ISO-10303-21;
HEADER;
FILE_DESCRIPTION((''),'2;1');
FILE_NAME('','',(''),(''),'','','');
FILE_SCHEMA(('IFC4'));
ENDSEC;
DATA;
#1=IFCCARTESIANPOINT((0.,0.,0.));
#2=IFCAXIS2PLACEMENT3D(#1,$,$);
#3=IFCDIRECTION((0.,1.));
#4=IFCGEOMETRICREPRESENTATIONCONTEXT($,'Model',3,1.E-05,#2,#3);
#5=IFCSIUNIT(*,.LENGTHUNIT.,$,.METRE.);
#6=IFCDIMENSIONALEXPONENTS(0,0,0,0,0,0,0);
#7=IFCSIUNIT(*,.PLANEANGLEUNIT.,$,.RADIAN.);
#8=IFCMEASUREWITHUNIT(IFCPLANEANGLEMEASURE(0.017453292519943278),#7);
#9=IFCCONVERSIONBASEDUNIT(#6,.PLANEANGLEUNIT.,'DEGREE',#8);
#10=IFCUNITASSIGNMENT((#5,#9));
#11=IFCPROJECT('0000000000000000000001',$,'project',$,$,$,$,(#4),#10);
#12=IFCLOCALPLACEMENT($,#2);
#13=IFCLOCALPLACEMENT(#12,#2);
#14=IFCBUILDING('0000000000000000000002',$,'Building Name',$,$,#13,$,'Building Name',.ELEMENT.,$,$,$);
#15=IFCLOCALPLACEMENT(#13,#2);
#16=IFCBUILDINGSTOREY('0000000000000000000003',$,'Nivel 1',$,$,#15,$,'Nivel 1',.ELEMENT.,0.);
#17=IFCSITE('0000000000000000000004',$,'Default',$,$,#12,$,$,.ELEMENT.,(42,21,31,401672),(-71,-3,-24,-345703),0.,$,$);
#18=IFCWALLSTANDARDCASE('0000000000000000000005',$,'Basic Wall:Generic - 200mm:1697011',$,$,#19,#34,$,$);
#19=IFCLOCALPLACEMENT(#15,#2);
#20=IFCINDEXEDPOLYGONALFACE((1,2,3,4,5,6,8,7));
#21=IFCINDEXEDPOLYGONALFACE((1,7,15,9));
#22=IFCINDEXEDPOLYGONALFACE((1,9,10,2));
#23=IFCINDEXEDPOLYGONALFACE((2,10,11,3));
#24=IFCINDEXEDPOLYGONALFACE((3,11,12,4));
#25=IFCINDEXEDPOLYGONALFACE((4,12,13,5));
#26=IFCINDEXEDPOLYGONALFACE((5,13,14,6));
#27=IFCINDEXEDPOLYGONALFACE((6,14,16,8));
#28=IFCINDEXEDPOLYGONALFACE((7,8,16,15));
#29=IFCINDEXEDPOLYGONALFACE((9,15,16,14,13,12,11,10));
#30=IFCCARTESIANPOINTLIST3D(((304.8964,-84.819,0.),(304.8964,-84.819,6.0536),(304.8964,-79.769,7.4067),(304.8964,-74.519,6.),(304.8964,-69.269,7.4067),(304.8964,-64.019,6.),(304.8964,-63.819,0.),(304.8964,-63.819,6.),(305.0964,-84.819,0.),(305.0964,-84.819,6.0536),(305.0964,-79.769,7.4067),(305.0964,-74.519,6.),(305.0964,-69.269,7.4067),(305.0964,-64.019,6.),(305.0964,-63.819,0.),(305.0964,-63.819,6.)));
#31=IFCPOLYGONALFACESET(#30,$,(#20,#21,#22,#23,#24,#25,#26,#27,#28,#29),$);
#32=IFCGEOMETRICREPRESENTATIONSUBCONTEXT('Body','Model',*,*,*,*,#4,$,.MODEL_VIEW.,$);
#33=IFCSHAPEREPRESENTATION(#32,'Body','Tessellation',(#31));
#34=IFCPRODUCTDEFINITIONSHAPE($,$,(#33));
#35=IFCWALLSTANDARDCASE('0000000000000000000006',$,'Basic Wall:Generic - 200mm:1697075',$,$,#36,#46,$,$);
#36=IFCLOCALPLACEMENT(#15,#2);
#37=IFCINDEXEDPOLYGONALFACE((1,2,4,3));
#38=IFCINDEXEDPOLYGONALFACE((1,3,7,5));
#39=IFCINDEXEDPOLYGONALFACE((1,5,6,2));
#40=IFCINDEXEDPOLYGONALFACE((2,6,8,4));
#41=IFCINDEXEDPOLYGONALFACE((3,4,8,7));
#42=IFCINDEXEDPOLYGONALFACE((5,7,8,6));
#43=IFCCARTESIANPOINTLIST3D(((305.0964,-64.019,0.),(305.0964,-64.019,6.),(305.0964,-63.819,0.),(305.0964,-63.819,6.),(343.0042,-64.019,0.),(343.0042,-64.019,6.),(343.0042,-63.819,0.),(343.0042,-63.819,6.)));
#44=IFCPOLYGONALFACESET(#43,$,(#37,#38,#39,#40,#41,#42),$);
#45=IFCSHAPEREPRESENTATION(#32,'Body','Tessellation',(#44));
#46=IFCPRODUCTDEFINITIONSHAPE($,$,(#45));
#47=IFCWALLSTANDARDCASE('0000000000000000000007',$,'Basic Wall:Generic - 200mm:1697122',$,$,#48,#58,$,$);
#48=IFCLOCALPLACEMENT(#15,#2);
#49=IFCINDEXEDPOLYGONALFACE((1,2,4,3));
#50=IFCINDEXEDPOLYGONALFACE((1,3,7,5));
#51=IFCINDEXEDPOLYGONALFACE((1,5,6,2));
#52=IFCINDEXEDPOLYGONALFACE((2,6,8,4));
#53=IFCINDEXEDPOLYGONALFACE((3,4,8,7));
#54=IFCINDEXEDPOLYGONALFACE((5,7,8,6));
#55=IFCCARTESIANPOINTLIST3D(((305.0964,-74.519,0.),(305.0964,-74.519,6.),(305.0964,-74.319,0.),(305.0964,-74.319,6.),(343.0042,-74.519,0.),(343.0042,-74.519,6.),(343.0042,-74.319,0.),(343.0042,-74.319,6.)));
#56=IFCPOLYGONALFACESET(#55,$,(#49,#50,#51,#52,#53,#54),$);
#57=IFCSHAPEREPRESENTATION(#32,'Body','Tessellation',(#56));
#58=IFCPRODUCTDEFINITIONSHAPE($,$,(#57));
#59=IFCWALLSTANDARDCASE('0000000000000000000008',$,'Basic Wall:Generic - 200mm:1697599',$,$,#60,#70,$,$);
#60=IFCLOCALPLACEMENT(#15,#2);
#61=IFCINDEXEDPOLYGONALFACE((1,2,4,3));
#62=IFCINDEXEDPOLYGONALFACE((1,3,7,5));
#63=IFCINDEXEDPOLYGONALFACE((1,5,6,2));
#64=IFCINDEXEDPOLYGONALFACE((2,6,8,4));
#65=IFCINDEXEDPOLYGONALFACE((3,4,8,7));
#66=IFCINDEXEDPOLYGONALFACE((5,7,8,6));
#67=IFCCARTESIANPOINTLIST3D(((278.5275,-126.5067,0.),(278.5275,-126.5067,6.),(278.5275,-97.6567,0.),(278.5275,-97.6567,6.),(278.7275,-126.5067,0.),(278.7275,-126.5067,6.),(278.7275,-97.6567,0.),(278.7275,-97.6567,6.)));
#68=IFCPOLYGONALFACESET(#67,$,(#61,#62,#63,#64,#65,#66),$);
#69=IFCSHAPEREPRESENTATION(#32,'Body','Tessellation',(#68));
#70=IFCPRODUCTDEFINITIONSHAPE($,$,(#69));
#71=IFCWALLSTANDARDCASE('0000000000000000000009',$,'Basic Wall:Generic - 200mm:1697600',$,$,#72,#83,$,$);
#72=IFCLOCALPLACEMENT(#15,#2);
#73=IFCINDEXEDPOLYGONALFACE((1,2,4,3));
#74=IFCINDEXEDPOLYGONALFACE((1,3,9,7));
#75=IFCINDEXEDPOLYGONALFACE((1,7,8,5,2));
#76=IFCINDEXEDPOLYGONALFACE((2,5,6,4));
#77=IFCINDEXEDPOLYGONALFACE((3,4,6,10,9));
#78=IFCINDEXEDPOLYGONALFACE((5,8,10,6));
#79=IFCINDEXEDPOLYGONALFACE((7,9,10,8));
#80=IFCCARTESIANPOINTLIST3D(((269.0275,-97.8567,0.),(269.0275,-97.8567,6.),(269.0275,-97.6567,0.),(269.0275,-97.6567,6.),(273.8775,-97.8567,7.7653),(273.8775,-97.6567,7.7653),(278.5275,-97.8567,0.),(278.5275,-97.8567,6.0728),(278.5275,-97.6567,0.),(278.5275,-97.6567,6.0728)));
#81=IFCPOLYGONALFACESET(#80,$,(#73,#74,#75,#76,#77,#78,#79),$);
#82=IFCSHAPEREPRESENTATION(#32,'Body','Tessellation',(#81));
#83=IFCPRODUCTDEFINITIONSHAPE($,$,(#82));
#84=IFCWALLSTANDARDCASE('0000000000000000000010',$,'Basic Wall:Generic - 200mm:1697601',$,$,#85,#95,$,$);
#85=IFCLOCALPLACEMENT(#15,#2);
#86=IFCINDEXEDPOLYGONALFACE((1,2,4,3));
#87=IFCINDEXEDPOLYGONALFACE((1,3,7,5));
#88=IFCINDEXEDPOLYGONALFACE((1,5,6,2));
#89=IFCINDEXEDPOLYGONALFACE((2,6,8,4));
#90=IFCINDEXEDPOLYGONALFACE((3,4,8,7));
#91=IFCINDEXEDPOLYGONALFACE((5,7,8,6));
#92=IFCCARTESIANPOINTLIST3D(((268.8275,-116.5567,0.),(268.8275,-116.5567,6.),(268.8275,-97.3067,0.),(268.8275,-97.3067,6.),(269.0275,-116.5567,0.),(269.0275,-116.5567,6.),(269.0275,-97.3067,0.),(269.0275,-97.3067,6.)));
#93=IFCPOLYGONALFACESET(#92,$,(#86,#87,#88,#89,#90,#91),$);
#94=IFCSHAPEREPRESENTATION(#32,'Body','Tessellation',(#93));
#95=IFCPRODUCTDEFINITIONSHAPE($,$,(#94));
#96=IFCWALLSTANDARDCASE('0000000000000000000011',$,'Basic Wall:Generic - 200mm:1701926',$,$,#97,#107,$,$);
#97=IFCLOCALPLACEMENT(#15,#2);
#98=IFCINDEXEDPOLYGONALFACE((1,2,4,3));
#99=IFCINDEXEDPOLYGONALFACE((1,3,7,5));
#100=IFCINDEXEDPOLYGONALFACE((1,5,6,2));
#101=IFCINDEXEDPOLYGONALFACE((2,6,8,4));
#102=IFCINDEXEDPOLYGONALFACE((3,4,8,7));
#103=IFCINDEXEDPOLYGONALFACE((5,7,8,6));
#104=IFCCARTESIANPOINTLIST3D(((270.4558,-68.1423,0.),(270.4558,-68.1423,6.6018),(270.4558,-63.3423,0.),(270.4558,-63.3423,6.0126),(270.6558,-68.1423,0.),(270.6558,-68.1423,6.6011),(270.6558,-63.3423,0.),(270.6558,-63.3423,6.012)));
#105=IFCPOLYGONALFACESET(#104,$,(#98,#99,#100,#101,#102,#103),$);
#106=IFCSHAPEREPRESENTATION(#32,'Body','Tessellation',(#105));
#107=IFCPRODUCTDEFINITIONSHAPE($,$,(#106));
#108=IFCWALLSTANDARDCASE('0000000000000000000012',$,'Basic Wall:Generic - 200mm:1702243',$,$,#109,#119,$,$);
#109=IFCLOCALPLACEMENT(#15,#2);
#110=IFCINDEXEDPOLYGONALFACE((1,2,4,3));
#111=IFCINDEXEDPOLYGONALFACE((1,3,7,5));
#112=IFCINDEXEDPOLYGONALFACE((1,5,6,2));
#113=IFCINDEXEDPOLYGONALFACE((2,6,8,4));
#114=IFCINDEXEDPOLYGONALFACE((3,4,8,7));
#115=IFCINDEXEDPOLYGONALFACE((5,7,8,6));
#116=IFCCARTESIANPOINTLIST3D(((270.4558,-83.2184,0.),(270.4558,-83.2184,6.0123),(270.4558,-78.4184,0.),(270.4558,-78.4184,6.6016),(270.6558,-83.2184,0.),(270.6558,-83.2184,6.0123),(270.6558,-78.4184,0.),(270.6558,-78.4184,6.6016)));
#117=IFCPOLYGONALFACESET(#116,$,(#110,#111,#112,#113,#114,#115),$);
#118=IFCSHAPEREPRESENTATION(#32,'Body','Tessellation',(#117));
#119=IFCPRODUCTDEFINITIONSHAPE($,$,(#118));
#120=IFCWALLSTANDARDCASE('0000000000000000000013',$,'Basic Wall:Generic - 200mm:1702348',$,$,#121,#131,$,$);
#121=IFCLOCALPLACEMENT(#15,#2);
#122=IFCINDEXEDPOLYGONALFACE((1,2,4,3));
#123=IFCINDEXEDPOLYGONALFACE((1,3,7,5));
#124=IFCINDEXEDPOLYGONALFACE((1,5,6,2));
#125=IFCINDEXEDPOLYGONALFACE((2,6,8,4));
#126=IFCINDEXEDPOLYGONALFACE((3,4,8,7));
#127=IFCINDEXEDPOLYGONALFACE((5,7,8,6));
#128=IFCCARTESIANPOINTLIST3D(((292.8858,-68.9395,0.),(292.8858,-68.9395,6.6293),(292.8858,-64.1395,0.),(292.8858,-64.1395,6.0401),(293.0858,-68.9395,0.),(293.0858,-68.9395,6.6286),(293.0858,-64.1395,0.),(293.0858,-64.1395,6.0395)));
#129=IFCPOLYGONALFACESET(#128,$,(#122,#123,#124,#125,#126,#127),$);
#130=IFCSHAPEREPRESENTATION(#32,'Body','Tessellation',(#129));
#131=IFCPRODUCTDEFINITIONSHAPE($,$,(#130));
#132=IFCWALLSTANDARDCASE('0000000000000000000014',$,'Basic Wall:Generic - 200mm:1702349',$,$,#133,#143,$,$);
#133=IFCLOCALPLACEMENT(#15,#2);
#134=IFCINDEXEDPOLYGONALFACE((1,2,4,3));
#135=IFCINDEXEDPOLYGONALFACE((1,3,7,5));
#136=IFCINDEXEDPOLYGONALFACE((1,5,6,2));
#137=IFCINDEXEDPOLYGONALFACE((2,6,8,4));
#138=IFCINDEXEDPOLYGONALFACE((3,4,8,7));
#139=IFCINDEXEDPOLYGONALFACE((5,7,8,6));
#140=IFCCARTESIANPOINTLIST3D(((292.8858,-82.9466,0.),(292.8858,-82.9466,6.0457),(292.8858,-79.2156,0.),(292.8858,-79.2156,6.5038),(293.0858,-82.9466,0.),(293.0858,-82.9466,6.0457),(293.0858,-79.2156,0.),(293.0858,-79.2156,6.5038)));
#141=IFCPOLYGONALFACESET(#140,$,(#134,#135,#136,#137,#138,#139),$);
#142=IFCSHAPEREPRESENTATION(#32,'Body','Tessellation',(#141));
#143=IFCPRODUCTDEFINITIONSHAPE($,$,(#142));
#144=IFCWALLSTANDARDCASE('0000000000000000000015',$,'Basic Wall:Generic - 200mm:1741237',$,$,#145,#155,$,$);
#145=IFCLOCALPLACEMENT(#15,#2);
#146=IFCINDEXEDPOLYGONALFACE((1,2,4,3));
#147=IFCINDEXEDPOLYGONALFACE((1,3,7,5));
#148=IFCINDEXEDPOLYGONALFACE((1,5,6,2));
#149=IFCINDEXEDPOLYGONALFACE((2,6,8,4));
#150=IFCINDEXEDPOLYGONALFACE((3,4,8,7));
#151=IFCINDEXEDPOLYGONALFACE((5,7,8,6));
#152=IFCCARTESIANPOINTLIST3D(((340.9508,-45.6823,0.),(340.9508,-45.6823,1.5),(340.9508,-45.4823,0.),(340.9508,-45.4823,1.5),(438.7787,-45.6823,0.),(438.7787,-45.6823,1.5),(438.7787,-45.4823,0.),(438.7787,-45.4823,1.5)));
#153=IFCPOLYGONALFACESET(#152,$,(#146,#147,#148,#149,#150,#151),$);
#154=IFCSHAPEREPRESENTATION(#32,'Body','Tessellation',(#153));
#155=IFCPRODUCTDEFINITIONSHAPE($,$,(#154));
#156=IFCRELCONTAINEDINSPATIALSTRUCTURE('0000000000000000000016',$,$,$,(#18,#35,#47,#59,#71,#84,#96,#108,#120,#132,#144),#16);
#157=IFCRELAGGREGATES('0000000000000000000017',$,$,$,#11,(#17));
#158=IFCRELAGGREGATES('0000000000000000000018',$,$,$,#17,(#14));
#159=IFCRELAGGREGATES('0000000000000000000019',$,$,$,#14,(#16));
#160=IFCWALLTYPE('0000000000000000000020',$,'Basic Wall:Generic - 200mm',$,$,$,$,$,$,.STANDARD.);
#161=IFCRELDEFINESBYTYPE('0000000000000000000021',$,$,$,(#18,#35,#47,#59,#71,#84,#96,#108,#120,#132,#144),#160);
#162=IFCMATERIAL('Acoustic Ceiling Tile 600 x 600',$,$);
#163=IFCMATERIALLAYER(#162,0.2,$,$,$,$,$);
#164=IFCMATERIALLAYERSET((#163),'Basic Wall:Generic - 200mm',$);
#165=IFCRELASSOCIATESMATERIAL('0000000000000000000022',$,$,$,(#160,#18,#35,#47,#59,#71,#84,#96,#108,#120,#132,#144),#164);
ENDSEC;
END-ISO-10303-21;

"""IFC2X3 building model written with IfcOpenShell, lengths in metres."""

from ifc_helpers import new_model, entity, si_unit, converted_unit, direction, frame, frame_2d, origin, place, context, subcontext, project, spatial, polyline, rectangle, extrude, clip, bounded_halfspace, material, layer, layer_set, layer_usage, type_object, element, save


model = new_model("IFC2X3")

# Units and contexts
model_context = context("Model", 3, precision=1e-05, world=origin(), true_north=direction((0.0, 1.0)))
body_context = subcontext(model_context, "Body", "Model", "MODEL_VIEW")
ifc_project = project(units=[si_unit("LENGTHUNIT", "METRE"), converted_unit("PLANEANGLEUNIT", "DEGREE", entity("IfcPlaneAngleMeasure", 0.017453292519943278), si_unit("PLANEANGLEUNIT", "RADIAN"), dimensions=[0, 0, 0, 0, 0, 0, 0])], contexts=[model_context])

# Site, building, storey
site_placement = place(None, origin())
site = spatial("IfcSite", under=ifc_project, at=site_placement, Name="Default", CompositionType="ELEMENT", RefLatitude=(42, 21, 31, 401672), RefLongitude=(-71, -3, -24, -345703), RefElevation=0.0)
building_placement = place(site_placement, origin())
building = spatial("IfcBuilding", under=site, at=building_placement, Name="Building Name", LongName="Building Name", CompositionType="ELEMENT")
storey_placement = place(building_placement, origin())
storey = spatial("IfcBuildingStorey", under=building, at=storey_placement, Name="Nivel 1", LongName="Nivel 1", CompositionType="ELEMENT", Elevation=0.0)

# Walls
ifc_material_1 = material(Name="Acoustic Ceiling Tile 600 x 600")
ifc_layer = layer(ifc_material_1, 0.2)
ifc_layer_set = layer_set([ifc_layer], Name="Basic Wall:Generic - 200mm")
wall_type_1 = type_object("IfcWallType", Name="Basic Wall:Generic - 200mm", PredefinedType="STANDARD", material=ifc_layer_set)
ifc_layer_usage_1 = layer_usage(ifc_layer_set, "AXIS2", "NEGATIVE", 0.1)
wall_1_placement = place(storey_placement, frame((304.9964, -84.819, 0.0), z_axis=(0.0, 0.0, 1.0), x_axis=(0.0, 1.0, 0.0)))
element("IfcWallStandardCase", 1, at=wall_1_placement, inside=storey, type_object=wall_type_1, material=ifc_layer_usage_1, Name="Basic Wall:Generic - 200mm:1697011", context=body_context, shape_type="Clipping", body=[
    clip(clip(clip(clip(clip(extrude(rectangle(XDim=21.0, YDim=0.2, at=frame_2d((10.5, 0.0), x_axis=(-1.0, 0.0))), origin(), (0.0, 0.0, 1.0), 7.4067), bounded_halfspace(frame((10.3, -0.1, 6.0), z_axis=(-0.258819, 0.0, 0.965926), x_axis=(0.0, -1.0, 0.0)), False, frame((10.3, -0.1, 6.0)), polyline([(0.0, 0.0), (5.25, 0.0), (5.25, 0.2), (0.0, 0.2), (0.0, 0.0)]))), bounded_halfspace(frame((0.0, -0.1, 6.0536), z_axis=(-0.258819, 0.0, 0.965926), x_axis=(0.0, -1.0, 0.0)), False, frame((0.0, -0.1, 6.0536)), polyline([(0.0, 0.0), (5.05, 0.0), (5.05, 0.2), (0.0, 0.2), (0.0, 0.0)]))), bounded_halfspace(frame((15.55, -0.1, 7.4067), z_axis=(0.258819, 0.0, 0.965926), x_axis=(0.0, 1.0, 0.0)), False, frame((15.55, -0.1, 7.4067)), polyline([(0.0, 0.0), (5.25, 0.0), (5.25, 0.2), (0.0, 0.2), (0.0, 0.0)]))), bounded_halfspace(frame((5.05, -0.1, 7.4067), z_axis=(0.258819, 0.0, 0.965926), x_axis=(0.0, 1.0, 0.0)), False, frame((5.05, -0.1, 7.4067)), polyline([(0.0, 0.0), (5.25, 0.0), (5.25, 0.2), (0.0, 0.2), (0.0, 0.0)]))), bounded_halfspace(frame((20.8, -0.1, 6.0), z_axis=(0.0, 0.0, 1.0), x_axis=(0.0, 1.0, 0.0)), False, frame((20.8, -0.1, 6.0)), polyline([(0.0, 0.0), (0.2, 0.0), (0.2, 0.2), (0.0, 0.2), (0.0, 0.0)]))),
])
ifc_layer_usage_2 = layer_usage(ifc_layer_set, "AXIS2", "NEGATIVE", 0.1)
wall_2_placement = place(storey_placement, frame((305.0964, -63.919, 0.0)))
element("IfcWallStandardCase", 2, at=wall_2_placement, inside=storey, type_object=wall_type_1, material=ifc_layer_usage_2, Name="Basic Wall:Generic - 200mm:1697075", context=body_context, shape_type="SweptSolid", body=[
    extrude(rectangle(XDim=37.9079, YDim=0.2, at=frame_2d((18.9539, 0.0), x_axis=(-1.0, 0.0))), origin(), (0.0, 0.0, 1.0), 6.0),
])
ifc_layer_usage_3 = layer_usage(ifc_layer_set, "AXIS2", "NEGATIVE", 0.1)
wall_3_placement = place(storey_placement, frame((343.0042, -74.419, 0.0), z_axis=(0.0, 0.0, 1.0), x_axis=(-1.0, 0.0, 0.0)))
element("IfcWallStandardCase", 3, at=wall_3_placement, inside=storey, type_object=wall_type_1, material=ifc_layer_usage_3, Name="Basic Wall:Generic - 200mm:1697122", context=body_context, shape_type="SweptSolid", body=[
    extrude(rectangle(XDim=37.9079, YDim=0.2, at=frame_2d((18.9539, 0.0), x_axis=(-1.0, 0.0))), origin(), (0.0, 0.0, 1.0), 6.0),
])
ifc_layer_usage_4 = layer_usage(ifc_layer_set, "AXIS2", "NEGATIVE", 0.1)
wall_4_placement = place(storey_placement, frame((278.6275, -126.5067, 0.0), z_axis=(0.0, 0.0, 1.0), x_axis=(0.0, 1.0, 0.0)))
element("IfcWallStandardCase", 4, at=wall_4_placement, inside=storey, type_object=wall_type_1, material=ifc_layer_usage_4, Name="Basic Wall:Generic - 200mm:1697599", context=body_context, shape_type="SweptSolid", body=[
    extrude(rectangle(XDim=28.85, YDim=0.2, at=frame_2d((14.425, 0.0), x_axis=(-1.0, 0.0))), origin(), (0.0, 0.0, 1.0), 6.0),
])
ifc_layer_usage_5 = layer_usage(ifc_layer_set, "AXIS2", "NEGATIVE", 0.1)
wall_5_placement = place(storey_placement, frame((278.5275, -97.7567, 0.0), z_axis=(0.0, 0.0, 1.0), x_axis=(-1.0, 0.0, 0.0)))
element("IfcWallStandardCase", 5, at=wall_5_placement, inside=storey, type_object=wall_type_1, material=ifc_layer_usage_5, Name="Basic Wall:Generic - 200mm:1697600", context=body_context, shape_type="Clipping", body=[
    clip(clip(extrude(rectangle(XDim=9.5, YDim=0.2, at=frame_2d((4.75, 0.0), x_axis=(-1.0, 0.0))), origin(), (0.0, 0.0, 1.0), 7.7653), bounded_halfspace(frame((0.0, -0.1, 6.0728), z_axis=(-0.34202, 0.0, 0.939693), x_axis=(0.0, -1.0, 0.0)), False, frame((0.0, -0.1, 6.0728)), polyline([(0.0, 0.0), (4.65, 0.0), (4.65, 0.2), (0.0, 0.2), (0.0, 0.0)]))), bounded_halfspace(frame((4.65, -0.1, 7.7653), z_axis=(0.34202, 0.0, 0.939693), x_axis=(0.0, 1.0, 0.0)), False, frame((4.65, -0.1, 7.7653)), polyline([(0.0, 0.0), (4.85, 0.0), (4.85, 0.2), (0.0, 0.2), (0.0, 0.0)]))),
])
ifc_layer_usage_6 = layer_usage(ifc_layer_set, "AXIS2", "NEGATIVE", 0.1)
wall_6_placement = place(storey_placement, frame((268.9275, -97.3067, 0.0), z_axis=(0.0, 0.0, 1.0), x_axis=(0.0, -1.0, 0.0)))
element("IfcWallStandardCase", 6, at=wall_6_placement, inside=storey, type_object=wall_type_1, material=ifc_layer_usage_6, Name="Basic Wall:Generic - 200mm:1697601", context=body_context, shape_type="SweptSolid", body=[
    extrude(rectangle(XDim=19.25, YDim=0.2, at=frame_2d((9.625, 0.0), x_axis=(-1.0, 0.0))), origin(), (0.0, 0.0, 1.0), 6.0),
])
ifc_layer_usage_7 = layer_usage(ifc_layer_set, "AXIS2", "NEGATIVE", 0.1)
wall_7_placement = place(storey_placement, frame((270.5558, -68.1423, 0.0), z_axis=(0.0, 0.0, 1.0), x_axis=(0.0, 1.0, 0.0)))
element("IfcWallStandardCase", 7, at=wall_7_placement, inside=storey, type_object=wall_type_1, material=ifc_layer_usage_7, Name="Basic Wall:Generic - 200mm:1701926", context=body_context, shape_type="Clipping", body=[
    clip(extrude(rectangle(XDim=4.8, YDim=0.2, at=frame_2d((2.4, 0.0), x_axis=(-1.0, 0.0))), origin(), (0.0, 0.0, 1.0), 6.6018), bounded_halfspace(frame((0.0, -0.1, 6.6011), z_axis=(0.12183, -0.003114, 0.992546), x_axis=(0.025549, 0.999674, 0.0)), False, frame((0.0, -0.1, 6.6011)), polyline([(0.0, 0.0), (4.8, 0.0), (4.8, 0.2), (0.0, 0.2), (0.0, 0.0)]))),
])
ifc_layer_usage_8 = layer_usage(ifc_layer_set, "AXIS2", "NEGATIVE", 0.1)
wall_8_placement = place(storey_placement, frame((270.5558, -83.2184, 0.0), z_axis=(0.0, 0.0, 1.0), x_axis=(0.0, 1.0, 0.0)))
element("IfcWallStandardCase", 8, at=wall_8_placement, inside=storey, type_object=wall_type_1, material=ifc_layer_usage_8, Name="Basic Wall:Generic - 200mm:1702243", context=body_context, shape_type="Clipping", body=[
    clip(extrude(rectangle(XDim=4.8, YDim=0.2, at=frame_2d((2.4, 0.0), x_axis=(-1.0, 0.0))), origin(), (0.0, 0.0, 1.0), 6.6016), bounded_halfspace(frame((0.0, -0.1, 6.0123), z_axis=(-0.121869, 0.0, 0.992546), x_axis=(0.0, -1.0, 0.0)), False, frame((0.0, -0.1, 6.0123)), polyline([(0.0, 0.0), (4.8, 0.0), (4.8, 0.2), (0.0, 0.2), (0.0, 0.0)]))),
])
ifc_layer_usage_9 = layer_usage(ifc_layer_set, "AXIS2", "NEGATIVE", 0.1)
wall_9_placement = place(storey_placement, frame((292.9858, -68.9395, 0.0), z_axis=(0.0, 0.0, 1.0), x_axis=(0.0, 1.0, 0.0)))
element("IfcWallStandardCase", 9, at=wall_9_placement, inside=storey, type_object=wall_type_1, material=ifc_layer_usage_9, Name="Basic Wall:Generic - 200mm:1702348", context=body_context, shape_type="Clipping", body=[
    clip(extrude(rectangle(XDim=4.8, YDim=0.2, at=frame_2d((2.4, 0.0), x_axis=(-1.0, 0.0))), origin(), (0.0, 0.0, 1.0), 6.6293), bounded_halfspace(frame((0.0, -0.1, 6.6286), z_axis=(0.12183, -0.003114, 0.992546), x_axis=(0.025549, 0.999674, 0.0)), False, frame((0.0, -0.1, 6.6286)), polyline([(0.0, 0.0), (4.8, 0.0), (4.8, 0.2), (0.0, 0.2), (0.0, 0.0)]))),
])
ifc_layer_usage_10 = layer_usage(ifc_layer_set, "AXIS2", "NEGATIVE", 0.1)
wall_10_placement = place(storey_placement, frame((292.9858, -82.9466, 0.0), z_axis=(0.0, 0.0, 1.0), x_axis=(0.0, 1.0, 0.0)))
element("IfcWallStandardCase", 10, at=wall_10_placement, inside=storey, type_object=wall_type_1, material=ifc_layer_usage_10, Name="Basic Wall:Generic - 200mm:1702349", context=body_context, shape_type="Clipping", body=[
    clip(extrude(rectangle(XDim=3.7309, YDim=0.2, at=frame_2d((1.8655, 0.0), x_axis=(-1.0, 0.0))), origin(), (0.0, 0.0, 1.0), 6.5038), bounded_halfspace(frame((0.0, -0.1, 6.0457), z_axis=(-0.121869, 0.0, 0.992546), x_axis=(0.0, -1.0, 0.0)), False, frame((0.0, -0.1, 6.0457)), polyline([(0.0, 0.0), (3.7309, 0.0), (3.7309, 0.2), (0.0, 0.2), (0.0, 0.0)]))),
])
ifc_layer_usage_11 = layer_usage(ifc_layer_set, "AXIS2", "NEGATIVE", 0.1)
wall_11_placement = place(storey_placement, frame((340.9508, -45.5823, 0.0)))
element("IfcWallStandardCase", 11, at=wall_11_placement, inside=storey, type_object=wall_type_1, material=ifc_layer_usage_11, Name="Basic Wall:Generic - 200mm:1741237", context=body_context, shape_type="SweptSolid", body=[
    extrude(rectangle(XDim=97.8279, YDim=0.2, at=frame_2d((48.914, 0.0), x_axis=(-1.0, 0.0))), origin(), (0.0, 0.0, 1.0), 1.5),
])

save(model, "model.ifc")
